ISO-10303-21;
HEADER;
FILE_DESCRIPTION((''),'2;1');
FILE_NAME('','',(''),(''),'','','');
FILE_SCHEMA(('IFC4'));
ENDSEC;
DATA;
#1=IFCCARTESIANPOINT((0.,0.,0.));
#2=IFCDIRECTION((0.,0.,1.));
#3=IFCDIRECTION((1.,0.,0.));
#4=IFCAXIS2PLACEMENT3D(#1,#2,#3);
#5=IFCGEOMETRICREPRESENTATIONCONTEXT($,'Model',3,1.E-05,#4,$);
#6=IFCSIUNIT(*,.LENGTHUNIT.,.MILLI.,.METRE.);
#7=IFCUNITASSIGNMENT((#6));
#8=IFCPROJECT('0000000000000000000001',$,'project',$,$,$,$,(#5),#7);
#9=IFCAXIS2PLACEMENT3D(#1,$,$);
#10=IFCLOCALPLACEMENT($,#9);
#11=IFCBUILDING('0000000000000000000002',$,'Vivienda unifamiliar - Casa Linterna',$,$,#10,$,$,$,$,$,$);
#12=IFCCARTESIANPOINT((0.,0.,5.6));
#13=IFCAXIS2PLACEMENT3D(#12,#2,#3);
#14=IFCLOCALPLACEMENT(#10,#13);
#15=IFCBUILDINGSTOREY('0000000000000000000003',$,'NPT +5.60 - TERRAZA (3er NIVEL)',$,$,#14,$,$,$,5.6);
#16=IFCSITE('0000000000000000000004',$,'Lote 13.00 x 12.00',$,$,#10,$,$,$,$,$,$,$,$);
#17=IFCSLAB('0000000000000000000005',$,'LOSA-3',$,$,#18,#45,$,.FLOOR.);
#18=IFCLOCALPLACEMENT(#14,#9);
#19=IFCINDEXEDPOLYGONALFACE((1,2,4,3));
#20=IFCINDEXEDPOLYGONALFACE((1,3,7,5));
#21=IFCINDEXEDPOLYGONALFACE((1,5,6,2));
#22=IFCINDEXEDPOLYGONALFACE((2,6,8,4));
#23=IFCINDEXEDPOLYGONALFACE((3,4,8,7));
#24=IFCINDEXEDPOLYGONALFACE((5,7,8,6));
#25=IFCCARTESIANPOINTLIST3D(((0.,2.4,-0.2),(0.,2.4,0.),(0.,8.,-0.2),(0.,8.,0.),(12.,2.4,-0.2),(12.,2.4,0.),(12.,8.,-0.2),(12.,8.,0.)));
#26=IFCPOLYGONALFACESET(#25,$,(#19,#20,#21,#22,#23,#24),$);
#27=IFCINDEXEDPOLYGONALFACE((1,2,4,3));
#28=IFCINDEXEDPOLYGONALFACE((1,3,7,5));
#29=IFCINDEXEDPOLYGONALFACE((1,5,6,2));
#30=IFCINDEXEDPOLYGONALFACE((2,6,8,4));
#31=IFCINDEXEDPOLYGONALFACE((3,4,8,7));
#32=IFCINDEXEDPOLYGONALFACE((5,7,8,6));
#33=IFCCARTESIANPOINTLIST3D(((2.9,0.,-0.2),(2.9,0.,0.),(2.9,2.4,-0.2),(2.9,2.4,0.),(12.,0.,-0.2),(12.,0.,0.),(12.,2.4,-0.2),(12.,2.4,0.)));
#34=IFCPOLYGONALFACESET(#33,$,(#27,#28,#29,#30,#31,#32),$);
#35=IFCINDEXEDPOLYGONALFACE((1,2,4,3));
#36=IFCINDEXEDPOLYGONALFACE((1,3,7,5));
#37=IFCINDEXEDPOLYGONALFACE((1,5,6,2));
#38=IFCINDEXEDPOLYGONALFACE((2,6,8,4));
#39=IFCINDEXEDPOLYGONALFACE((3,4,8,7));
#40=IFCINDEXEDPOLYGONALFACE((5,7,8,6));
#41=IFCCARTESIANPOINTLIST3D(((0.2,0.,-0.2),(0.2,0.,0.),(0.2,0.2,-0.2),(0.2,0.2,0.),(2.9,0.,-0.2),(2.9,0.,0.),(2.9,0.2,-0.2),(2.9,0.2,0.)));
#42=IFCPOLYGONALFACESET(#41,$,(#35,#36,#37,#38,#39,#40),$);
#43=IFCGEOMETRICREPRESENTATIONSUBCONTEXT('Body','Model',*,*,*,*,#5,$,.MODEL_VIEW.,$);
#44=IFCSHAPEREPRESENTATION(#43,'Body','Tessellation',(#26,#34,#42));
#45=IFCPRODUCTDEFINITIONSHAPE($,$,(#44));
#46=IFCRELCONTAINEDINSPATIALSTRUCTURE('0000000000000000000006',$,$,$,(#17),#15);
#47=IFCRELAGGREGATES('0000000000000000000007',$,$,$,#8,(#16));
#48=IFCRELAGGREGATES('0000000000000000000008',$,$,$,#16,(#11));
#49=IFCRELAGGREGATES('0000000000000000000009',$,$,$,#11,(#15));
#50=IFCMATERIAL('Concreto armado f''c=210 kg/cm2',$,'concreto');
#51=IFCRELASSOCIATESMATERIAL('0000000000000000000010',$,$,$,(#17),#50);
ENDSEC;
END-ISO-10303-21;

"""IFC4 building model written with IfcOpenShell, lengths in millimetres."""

from ifc_helpers import new_model, si_unit, frame, origin, origin_with_axes, place, context, subcontext, project, spatial, polyline, outline, extrude, material, element, save


model = new_model("IFC4")

# Units and contexts
model_context = context("Model", 3, precision=1e-05, world=origin_with_axes())
body_context = subcontext(model_context, "Body", "Model", "MODEL_VIEW")
ifc_project = project(units=[si_unit("LENGTHUNIT", "METRE", prefix="MILLI")], contexts=[model_context])

# Site, building, storey
placement = place(None, origin())
site = spatial("IfcSite", under=ifc_project, at=placement, Name="Lote 13.00 x 12.00")
building = spatial("IfcBuilding", under=site, at=placement, Name="Vivienda unifamiliar - Casa Linterna")
storey_placement = place(placement, frame((0.0, 0.0, 5.6), z_axis=(0.0, 0.0, 1.0), x_axis=(1.0, 0.0, 0.0)))
storey = spatial("IfcBuildingStorey", under=building, at=storey_placement, Name="NPT +5.60 - TERRAZA (3er NIVEL)", Elevation=5.6)

# Shared definitions
ifc_material_1 = material(Name="Concreto armado f'c=210 kg/cm2", Category="concreto")

# Slab
slab_placement = place(storey_placement, frame((0.0, 0.0, -5.6), z_axis=(0.0, 0.0, 1.0), x_axis=(1.0, 0.0, 0.0)))
element("IfcSlab", 1, at=slab_placement, inside=storey, material=ifc_material_1, Name="LOSA-3", PredefinedType="FLOOR", context=body_context, shape_type="SweptSolid", body=[
    extrude(outline(polyline([(2.4, 5.4), (8.0, 5.4), (8.0, 5.6), (2.4, 5.6), (2.4, 5.4)])), frame((0.0, 0.0, 0.0), z_axis=(1.0, 0.0, 0.0), x_axis=(0.0, 1.0, 0.0)), (0.0, 0.0, 1.0), 12.0),
    extrude(outline(polyline([(0.0, 5.4), (2.4, 5.4), (2.4, 5.6), (0.0, 5.6), (0.0, 5.4)])), frame((2.9, 0.0, 0.0), z_axis=(1.0, 0.0, 0.0), x_axis=(0.0, 1.0, 0.0)), (0.0, 0.0, 1.0), 9.1),
    extrude(outline(polyline([(0.0, 5.4), (0.1, 5.4), (0.1, 5.6), (0.0, 5.6), (0.0, 5.4)])), frame((0.1, 0.0, 0.0), z_axis=(1.0, 0.0, 0.0), x_axis=(0.0, 1.0, 0.0)), (0.0, 0.0, 1.0), 2.8),
])

save(model, "model.ifc")
